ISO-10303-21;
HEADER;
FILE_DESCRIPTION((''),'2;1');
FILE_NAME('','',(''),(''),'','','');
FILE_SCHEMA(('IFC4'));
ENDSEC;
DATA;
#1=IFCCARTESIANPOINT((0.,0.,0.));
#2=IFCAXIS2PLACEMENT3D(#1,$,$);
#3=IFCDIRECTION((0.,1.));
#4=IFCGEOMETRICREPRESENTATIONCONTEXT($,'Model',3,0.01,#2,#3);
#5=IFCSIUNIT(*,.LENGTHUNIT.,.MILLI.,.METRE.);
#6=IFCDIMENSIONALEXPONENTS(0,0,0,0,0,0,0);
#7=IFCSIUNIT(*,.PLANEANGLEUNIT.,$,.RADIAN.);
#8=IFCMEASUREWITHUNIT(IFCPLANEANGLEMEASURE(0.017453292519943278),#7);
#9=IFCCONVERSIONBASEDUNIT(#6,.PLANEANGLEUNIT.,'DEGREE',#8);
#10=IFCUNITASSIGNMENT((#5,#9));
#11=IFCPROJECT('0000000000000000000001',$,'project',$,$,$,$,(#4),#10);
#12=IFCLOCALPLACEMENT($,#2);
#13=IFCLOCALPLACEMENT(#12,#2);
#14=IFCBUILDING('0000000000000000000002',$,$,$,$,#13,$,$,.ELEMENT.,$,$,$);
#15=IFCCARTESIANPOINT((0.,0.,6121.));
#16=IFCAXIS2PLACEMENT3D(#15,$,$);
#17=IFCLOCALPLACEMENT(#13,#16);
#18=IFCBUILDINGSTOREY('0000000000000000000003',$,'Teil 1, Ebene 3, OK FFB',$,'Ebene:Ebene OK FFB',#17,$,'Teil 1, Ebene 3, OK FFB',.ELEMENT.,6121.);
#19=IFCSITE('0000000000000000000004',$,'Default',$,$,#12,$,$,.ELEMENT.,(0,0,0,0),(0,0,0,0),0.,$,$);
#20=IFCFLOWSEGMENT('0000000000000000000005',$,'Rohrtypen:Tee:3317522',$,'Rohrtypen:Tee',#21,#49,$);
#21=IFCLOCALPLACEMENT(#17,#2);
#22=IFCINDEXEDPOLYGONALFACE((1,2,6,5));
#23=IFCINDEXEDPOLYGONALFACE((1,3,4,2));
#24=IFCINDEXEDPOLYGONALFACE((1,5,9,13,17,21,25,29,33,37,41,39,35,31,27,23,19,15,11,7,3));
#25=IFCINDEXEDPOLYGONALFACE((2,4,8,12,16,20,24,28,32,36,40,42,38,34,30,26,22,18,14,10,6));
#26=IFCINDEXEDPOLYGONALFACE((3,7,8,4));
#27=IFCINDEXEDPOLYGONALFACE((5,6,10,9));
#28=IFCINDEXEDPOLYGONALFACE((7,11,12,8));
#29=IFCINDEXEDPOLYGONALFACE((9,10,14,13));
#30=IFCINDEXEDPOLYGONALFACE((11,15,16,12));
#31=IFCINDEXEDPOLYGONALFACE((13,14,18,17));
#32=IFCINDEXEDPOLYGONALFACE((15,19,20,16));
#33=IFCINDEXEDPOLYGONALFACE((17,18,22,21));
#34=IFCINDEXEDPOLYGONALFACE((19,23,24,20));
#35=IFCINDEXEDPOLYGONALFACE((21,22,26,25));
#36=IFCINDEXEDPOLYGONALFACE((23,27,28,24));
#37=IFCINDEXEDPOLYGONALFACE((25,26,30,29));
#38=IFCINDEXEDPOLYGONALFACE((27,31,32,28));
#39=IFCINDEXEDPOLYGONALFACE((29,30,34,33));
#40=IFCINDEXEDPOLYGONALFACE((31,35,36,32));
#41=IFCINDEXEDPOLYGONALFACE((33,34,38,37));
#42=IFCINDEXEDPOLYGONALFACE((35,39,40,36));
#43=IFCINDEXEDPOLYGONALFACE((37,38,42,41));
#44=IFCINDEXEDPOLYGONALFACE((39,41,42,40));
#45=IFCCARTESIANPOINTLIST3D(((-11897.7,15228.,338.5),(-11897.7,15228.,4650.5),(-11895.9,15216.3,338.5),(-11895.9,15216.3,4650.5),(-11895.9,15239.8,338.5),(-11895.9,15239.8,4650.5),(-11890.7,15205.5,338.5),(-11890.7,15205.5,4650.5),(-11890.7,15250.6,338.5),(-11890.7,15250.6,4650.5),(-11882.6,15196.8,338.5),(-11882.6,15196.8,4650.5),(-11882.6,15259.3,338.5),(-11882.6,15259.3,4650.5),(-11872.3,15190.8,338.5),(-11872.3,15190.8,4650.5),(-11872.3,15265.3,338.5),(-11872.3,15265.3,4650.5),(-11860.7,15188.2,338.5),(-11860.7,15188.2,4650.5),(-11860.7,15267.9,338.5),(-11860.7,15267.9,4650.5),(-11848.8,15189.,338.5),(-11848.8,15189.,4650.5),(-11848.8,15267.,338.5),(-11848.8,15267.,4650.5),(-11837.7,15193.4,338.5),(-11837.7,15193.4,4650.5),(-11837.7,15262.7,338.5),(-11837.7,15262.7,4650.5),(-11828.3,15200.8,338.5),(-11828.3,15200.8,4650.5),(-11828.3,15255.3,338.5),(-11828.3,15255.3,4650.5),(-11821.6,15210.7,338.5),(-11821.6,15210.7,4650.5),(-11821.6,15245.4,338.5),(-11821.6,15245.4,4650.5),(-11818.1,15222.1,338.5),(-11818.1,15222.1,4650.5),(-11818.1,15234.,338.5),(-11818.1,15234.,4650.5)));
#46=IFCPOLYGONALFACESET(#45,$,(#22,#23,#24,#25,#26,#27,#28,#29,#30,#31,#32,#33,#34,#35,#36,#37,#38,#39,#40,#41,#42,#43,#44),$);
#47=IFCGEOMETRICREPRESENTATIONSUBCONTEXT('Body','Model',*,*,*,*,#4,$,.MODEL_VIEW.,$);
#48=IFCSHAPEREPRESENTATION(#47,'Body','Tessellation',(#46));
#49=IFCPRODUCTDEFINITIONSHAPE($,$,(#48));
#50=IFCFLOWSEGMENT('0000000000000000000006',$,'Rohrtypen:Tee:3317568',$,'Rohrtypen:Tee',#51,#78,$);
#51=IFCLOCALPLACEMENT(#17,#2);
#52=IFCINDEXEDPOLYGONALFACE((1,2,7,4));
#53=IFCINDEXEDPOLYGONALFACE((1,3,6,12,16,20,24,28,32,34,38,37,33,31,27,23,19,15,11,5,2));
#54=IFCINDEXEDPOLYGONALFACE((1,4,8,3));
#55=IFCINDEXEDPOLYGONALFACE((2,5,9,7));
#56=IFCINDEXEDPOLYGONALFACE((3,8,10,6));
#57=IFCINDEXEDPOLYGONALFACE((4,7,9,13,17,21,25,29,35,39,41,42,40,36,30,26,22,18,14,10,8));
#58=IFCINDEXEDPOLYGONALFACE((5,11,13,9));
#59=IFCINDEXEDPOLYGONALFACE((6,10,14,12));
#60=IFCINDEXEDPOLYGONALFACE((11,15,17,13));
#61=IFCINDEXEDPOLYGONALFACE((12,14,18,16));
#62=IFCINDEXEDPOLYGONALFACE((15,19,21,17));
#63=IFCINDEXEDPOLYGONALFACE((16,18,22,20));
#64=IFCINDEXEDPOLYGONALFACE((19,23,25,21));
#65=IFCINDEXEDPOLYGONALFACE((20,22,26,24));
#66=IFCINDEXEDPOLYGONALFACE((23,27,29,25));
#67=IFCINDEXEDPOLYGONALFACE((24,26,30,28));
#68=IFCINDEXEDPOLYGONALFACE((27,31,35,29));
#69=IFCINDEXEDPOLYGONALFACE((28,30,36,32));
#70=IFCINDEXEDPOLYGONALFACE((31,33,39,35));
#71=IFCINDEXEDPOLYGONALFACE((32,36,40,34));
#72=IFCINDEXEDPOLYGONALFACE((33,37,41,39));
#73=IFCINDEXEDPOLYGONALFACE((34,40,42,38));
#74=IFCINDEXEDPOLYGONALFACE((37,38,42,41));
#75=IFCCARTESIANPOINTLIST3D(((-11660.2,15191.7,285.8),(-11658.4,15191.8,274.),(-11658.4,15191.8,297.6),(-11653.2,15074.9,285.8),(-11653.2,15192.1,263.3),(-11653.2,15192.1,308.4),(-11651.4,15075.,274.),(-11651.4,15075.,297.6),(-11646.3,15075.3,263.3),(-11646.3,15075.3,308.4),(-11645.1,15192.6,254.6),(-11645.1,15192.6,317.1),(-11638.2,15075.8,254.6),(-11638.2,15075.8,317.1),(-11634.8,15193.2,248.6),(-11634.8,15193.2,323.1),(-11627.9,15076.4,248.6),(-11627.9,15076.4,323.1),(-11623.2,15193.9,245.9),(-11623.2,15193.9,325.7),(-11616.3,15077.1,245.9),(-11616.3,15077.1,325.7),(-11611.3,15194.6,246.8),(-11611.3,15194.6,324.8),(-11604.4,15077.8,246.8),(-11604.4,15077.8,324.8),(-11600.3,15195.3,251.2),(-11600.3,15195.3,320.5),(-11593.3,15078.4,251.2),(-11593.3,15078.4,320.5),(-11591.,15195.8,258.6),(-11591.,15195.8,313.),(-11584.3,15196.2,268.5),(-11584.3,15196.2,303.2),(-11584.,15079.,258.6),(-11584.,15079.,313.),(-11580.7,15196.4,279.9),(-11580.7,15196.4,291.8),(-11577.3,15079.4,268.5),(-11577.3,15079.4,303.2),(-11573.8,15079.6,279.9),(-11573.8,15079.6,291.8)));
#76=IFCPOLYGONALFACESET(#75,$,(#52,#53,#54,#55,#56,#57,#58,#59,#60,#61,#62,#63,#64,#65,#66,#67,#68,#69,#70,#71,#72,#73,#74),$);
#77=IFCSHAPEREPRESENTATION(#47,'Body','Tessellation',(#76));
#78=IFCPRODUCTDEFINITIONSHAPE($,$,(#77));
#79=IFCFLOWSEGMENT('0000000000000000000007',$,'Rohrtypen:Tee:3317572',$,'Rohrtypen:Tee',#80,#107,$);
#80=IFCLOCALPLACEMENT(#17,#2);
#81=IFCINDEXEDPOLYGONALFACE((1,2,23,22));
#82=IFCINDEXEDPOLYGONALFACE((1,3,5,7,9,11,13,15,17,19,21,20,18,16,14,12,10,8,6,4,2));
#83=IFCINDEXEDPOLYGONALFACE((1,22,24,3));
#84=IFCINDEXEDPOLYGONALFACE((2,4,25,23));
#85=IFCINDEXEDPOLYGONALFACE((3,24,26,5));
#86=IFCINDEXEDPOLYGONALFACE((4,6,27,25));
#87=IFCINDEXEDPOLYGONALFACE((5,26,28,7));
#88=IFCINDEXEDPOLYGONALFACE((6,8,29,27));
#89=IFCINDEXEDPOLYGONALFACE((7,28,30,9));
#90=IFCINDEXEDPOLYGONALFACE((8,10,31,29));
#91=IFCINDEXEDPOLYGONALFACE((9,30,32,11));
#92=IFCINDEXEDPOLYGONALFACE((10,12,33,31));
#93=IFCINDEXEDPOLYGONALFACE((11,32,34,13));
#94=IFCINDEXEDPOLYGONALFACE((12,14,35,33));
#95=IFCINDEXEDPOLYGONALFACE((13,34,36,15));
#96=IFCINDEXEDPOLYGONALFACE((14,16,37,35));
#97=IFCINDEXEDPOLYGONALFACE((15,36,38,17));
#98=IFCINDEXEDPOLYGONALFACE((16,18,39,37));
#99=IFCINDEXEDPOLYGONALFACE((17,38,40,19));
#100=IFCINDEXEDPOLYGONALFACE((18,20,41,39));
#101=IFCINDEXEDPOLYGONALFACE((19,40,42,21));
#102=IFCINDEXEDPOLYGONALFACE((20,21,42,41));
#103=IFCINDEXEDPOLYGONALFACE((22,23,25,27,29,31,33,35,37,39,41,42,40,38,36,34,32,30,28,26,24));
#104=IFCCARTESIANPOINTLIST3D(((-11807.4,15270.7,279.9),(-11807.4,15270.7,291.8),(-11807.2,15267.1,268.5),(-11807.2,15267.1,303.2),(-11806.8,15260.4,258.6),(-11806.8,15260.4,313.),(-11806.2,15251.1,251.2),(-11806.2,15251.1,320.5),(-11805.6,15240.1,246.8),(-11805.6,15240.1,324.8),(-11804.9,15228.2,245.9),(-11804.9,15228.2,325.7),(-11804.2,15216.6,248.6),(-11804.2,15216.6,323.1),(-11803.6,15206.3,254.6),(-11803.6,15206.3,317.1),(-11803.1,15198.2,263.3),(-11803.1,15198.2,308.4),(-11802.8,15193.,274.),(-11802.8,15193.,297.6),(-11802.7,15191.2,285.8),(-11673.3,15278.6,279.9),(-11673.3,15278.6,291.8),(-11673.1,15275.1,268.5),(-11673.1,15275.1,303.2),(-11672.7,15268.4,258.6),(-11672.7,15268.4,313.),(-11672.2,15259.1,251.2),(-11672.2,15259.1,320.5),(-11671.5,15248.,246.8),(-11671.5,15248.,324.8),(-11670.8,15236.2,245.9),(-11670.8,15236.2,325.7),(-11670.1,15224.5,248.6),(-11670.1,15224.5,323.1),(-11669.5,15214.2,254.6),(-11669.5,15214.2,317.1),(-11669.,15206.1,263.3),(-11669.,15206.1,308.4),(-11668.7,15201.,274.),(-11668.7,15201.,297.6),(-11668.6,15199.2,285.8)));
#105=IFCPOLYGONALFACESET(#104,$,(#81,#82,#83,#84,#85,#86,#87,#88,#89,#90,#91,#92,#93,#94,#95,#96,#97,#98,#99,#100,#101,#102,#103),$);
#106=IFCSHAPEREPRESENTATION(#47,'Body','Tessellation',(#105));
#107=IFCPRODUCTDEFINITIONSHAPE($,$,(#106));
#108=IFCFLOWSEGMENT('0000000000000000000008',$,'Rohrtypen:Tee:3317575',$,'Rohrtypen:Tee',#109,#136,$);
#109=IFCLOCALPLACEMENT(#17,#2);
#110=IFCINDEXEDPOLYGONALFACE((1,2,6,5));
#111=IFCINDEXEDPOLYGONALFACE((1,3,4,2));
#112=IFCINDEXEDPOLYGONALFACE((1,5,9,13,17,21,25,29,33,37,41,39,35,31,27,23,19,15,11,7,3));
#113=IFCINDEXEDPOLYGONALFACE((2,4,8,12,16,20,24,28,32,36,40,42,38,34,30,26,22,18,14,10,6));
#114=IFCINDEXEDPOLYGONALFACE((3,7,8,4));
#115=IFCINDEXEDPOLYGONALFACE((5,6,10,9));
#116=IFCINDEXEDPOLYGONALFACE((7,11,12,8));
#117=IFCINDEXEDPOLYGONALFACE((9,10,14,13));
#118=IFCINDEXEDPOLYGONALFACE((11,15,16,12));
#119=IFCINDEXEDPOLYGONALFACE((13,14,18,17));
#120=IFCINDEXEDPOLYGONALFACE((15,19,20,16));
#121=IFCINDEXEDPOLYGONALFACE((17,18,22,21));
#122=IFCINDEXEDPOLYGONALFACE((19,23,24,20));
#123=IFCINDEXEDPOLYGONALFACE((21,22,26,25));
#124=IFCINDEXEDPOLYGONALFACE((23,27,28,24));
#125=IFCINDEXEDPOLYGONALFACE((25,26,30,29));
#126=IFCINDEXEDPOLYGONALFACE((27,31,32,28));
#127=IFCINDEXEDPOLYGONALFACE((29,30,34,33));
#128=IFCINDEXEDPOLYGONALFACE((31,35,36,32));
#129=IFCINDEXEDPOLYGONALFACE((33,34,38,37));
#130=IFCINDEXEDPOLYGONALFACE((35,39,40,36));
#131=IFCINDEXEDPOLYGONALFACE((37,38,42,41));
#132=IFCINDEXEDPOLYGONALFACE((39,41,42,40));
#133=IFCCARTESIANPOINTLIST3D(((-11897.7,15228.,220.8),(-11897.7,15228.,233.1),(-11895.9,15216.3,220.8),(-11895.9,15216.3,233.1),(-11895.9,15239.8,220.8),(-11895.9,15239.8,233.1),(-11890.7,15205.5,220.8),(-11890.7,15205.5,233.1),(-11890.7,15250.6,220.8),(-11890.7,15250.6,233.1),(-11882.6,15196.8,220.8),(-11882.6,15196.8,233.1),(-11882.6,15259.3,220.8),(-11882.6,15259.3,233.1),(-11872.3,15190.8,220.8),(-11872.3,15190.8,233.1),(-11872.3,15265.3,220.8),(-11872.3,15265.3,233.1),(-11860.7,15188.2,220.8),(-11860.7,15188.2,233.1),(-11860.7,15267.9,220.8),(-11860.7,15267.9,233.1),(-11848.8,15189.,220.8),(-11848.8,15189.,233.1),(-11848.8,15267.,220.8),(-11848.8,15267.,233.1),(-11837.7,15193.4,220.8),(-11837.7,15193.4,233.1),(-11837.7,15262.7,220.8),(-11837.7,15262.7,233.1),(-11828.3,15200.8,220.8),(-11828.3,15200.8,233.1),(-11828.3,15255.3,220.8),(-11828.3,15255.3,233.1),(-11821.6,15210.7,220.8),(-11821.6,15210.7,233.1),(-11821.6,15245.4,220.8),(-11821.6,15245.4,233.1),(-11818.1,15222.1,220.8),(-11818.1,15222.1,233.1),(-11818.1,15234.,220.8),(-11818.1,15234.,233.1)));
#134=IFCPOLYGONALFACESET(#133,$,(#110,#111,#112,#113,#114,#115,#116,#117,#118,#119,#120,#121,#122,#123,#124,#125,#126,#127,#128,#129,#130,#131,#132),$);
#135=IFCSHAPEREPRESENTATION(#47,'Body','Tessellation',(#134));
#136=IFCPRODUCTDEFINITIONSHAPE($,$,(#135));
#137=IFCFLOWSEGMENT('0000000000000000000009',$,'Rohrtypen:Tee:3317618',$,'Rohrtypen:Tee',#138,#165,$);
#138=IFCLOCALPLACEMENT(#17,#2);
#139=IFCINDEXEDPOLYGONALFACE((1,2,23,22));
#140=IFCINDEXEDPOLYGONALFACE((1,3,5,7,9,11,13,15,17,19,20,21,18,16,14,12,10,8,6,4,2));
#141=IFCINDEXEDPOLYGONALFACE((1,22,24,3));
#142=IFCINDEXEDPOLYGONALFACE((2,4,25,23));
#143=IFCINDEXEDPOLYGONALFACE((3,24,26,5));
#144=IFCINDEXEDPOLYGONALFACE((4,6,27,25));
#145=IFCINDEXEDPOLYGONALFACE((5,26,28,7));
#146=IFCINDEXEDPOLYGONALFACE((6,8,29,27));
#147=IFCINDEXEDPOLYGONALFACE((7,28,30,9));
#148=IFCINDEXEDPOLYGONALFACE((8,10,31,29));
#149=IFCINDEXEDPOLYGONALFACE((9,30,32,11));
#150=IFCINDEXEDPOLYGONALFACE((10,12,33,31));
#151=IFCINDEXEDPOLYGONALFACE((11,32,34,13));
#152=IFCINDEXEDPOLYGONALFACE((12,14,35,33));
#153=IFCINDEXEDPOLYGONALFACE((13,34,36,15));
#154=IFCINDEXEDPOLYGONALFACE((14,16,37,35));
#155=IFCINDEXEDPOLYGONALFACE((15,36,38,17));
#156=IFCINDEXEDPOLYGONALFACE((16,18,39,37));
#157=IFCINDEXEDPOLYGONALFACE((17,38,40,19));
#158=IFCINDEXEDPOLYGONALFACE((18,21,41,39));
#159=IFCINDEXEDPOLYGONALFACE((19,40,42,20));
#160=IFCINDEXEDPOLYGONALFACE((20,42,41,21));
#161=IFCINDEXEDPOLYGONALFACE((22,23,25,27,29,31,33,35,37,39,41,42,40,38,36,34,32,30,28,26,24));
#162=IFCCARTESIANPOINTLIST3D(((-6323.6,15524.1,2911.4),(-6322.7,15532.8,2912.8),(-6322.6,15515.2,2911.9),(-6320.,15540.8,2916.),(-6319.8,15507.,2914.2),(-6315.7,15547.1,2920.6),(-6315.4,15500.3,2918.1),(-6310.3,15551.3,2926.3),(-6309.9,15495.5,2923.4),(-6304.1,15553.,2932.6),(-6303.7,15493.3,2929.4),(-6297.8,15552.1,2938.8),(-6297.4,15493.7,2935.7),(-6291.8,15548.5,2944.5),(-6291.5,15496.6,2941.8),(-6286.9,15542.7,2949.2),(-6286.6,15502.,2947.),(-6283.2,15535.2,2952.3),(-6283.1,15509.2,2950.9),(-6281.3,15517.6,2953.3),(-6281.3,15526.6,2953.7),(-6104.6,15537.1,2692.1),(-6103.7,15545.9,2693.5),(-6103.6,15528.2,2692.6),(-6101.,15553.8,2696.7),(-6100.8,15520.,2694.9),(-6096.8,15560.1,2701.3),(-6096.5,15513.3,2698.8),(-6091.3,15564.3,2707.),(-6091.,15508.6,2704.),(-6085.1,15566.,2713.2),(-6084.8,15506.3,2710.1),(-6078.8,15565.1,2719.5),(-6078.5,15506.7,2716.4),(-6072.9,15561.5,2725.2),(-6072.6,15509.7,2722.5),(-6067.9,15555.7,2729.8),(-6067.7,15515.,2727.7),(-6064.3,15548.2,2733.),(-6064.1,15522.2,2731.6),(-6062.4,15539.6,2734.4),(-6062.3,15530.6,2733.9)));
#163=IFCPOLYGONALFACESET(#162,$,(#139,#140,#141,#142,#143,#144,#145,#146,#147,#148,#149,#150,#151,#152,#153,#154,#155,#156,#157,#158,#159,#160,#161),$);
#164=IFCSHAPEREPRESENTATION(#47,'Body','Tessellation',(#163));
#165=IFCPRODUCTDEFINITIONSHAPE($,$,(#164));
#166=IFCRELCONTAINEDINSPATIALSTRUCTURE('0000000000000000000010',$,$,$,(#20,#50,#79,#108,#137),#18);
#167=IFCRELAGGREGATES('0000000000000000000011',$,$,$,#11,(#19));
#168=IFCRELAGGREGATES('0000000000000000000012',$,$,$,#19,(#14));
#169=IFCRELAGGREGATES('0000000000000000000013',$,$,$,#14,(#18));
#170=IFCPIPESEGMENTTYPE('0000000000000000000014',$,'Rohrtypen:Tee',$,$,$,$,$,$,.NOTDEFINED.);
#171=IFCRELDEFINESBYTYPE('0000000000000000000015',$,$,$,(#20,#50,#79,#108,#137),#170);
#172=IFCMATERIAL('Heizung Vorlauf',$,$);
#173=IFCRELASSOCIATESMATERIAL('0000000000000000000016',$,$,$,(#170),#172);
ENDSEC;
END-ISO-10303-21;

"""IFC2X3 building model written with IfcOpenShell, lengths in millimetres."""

from ifc_helpers import new_model, entity, si_unit, converted_unit, direction, frame, frame_2d, origin, origin_2d_with_axis, place, context, subcontext, project, spatial, circle, extrude, material, type_object, element, save


model = new_model("IFC2X3")

# Units and contexts
model_context = context("Model", 3, precision=0.01, world=origin(), true_north=direction((0.0, 1.0)))
body_context = subcontext(model_context, "Body", "Model", "MODEL_VIEW")
ifc_project = project(units=[si_unit("LENGTHUNIT", "METRE", prefix="MILLI"), converted_unit("PLANEANGLEUNIT", "DEGREE", entity("IfcPlaneAngleMeasure", 0.017453292519943278), si_unit("PLANEANGLEUNIT", "RADIAN"), dimensions=[0, 0, 0, 0, 0, 0, 0])], contexts=[model_context])

# Site, building, storey
site_placement = place(None, origin())
site = spatial("IfcSite", under=ifc_project, at=site_placement, Name="Default", CompositionType="ELEMENT", RefLatitude=(0, 0, 0, 0), RefLongitude=(0, 0, 0, 0), RefElevation=0.0)
building_placement = place(site_placement, origin())
building = spatial("IfcBuilding", under=site, at=building_placement, CompositionType="ELEMENT")
storey_placement = place(building_placement, frame((0.0, 0.0, 6121.0)))
storey = spatial("IfcBuildingStorey", under=building, at=storey_placement, Name="Teil 1, Ebene 3, OK FFB", ObjectType="Ebene:Ebene OK FFB", LongName="Teil 1, Ebene 3, OK FFB", CompositionType="ELEMENT", Elevation=6121.0)

# Flow segments
ifc_material = material(Name="Heizung Vorlauf")
pipe_segment_type = type_object("IfcPipeSegmentType", Name="Rohrtypen:Tee", PredefinedType="NOTDEFINED", material=ifc_material)
flow_segment_1_placement = place(storey_placement, origin())
element("IfcFlowSegment", 1, at=flow_segment_1_placement, inside=storey, type_object=pipe_segment_type, Name="Rohrtypen:Tee:3317522", ObjectType="Rohrtypen:Tee", context=body_context, shape_type="SweptSolid", body=[
    extrude(circle(Radius=40.0, at=origin_2d_with_axis()), frame((-11857.7, 15228.0, 338.5), z_axis=(0.0, 0.0, 1.0), x_axis=(-1.0, 0.0, 0.0)), (0.0, 0.0, 1.0), 4312.0),
])
flow_segment_2_placement = place(storey_placement, origin())
element("IfcFlowSegment", 2, at=flow_segment_2_placement, inside=storey, type_object=pipe_segment_type, Name="Rohrtypen:Tee:3317568", ObjectType="Rohrtypen:Tee", context=body_context, shape_type="SweptSolid", body=[
    extrude(circle(Radius=40.0, at=origin_2d_with_axis()), frame((-11620.2, 15194.1, 285.8), z_axis=(0.059319, -0.998239, 0.0), x_axis=(-0.998239, -0.059319, 0.0)), (0.0, 0.0, 1.0), 117.0),
])
flow_segment_3_placement = place(storey_placement, origin())
element("IfcFlowSegment", 3, at=flow_segment_3_placement, inside=storey, type_object=pipe_segment_type, Name="Rohrtypen:Tee:3317572", ObjectType="Rohrtypen:Tee", context=body_context, shape_type="SweptSolid", body=[
    extrude(circle(Radius=40.0, at=origin_2d_with_axis()), frame((-11805.1, 15231.2, 285.8), z_axis=(0.998239, 0.059319, 0.0), x_axis=(0.059319, -0.998239, 0.0)), (0.0, 0.0, 1.0), 134.3),
])
flow_segment_4_placement = place(storey_placement, origin())
element("IfcFlowSegment", 4, at=flow_segment_4_placement, inside=storey, type_object=pipe_segment_type, Name="Rohrtypen:Tee:3317575", ObjectType="Rohrtypen:Tee", context=body_context, shape_type="SweptSolid", body=[
    extrude(circle(Radius=40.0, at=origin_2d_with_axis()), frame((-11857.7, 15228.0, 220.8), z_axis=(0.0, 0.0, 1.0), x_axis=(-1.0, 0.0, 0.0)), (0.0, 0.0, 1.0), 12.3),
])
flow_segment_5_placement = place(storey_placement, origin())
element("IfcFlowSegment", 5, at=flow_segment_5_placement, inside=storey, type_object=pipe_segment_type, Name="Rohrtypen:Tee:3317618", ObjectType="Rohrtypen:Tee", context=body_context, shape_type="SweptSolid", body=[
    extrude(circle(Radius=30.0, at=frame_2d((0.0, 0.0), x_axis=(1.0, 0.0))), frame((-6302.3, 15523.1, 2932.6), z_axis=(0.705862, 0.041945, -0.707107), x_axis=(-0.059319, 0.998239, 0.0)), (0.0, 0.0, 1.0), 310.2),
])

save(model, "model.ifc")
